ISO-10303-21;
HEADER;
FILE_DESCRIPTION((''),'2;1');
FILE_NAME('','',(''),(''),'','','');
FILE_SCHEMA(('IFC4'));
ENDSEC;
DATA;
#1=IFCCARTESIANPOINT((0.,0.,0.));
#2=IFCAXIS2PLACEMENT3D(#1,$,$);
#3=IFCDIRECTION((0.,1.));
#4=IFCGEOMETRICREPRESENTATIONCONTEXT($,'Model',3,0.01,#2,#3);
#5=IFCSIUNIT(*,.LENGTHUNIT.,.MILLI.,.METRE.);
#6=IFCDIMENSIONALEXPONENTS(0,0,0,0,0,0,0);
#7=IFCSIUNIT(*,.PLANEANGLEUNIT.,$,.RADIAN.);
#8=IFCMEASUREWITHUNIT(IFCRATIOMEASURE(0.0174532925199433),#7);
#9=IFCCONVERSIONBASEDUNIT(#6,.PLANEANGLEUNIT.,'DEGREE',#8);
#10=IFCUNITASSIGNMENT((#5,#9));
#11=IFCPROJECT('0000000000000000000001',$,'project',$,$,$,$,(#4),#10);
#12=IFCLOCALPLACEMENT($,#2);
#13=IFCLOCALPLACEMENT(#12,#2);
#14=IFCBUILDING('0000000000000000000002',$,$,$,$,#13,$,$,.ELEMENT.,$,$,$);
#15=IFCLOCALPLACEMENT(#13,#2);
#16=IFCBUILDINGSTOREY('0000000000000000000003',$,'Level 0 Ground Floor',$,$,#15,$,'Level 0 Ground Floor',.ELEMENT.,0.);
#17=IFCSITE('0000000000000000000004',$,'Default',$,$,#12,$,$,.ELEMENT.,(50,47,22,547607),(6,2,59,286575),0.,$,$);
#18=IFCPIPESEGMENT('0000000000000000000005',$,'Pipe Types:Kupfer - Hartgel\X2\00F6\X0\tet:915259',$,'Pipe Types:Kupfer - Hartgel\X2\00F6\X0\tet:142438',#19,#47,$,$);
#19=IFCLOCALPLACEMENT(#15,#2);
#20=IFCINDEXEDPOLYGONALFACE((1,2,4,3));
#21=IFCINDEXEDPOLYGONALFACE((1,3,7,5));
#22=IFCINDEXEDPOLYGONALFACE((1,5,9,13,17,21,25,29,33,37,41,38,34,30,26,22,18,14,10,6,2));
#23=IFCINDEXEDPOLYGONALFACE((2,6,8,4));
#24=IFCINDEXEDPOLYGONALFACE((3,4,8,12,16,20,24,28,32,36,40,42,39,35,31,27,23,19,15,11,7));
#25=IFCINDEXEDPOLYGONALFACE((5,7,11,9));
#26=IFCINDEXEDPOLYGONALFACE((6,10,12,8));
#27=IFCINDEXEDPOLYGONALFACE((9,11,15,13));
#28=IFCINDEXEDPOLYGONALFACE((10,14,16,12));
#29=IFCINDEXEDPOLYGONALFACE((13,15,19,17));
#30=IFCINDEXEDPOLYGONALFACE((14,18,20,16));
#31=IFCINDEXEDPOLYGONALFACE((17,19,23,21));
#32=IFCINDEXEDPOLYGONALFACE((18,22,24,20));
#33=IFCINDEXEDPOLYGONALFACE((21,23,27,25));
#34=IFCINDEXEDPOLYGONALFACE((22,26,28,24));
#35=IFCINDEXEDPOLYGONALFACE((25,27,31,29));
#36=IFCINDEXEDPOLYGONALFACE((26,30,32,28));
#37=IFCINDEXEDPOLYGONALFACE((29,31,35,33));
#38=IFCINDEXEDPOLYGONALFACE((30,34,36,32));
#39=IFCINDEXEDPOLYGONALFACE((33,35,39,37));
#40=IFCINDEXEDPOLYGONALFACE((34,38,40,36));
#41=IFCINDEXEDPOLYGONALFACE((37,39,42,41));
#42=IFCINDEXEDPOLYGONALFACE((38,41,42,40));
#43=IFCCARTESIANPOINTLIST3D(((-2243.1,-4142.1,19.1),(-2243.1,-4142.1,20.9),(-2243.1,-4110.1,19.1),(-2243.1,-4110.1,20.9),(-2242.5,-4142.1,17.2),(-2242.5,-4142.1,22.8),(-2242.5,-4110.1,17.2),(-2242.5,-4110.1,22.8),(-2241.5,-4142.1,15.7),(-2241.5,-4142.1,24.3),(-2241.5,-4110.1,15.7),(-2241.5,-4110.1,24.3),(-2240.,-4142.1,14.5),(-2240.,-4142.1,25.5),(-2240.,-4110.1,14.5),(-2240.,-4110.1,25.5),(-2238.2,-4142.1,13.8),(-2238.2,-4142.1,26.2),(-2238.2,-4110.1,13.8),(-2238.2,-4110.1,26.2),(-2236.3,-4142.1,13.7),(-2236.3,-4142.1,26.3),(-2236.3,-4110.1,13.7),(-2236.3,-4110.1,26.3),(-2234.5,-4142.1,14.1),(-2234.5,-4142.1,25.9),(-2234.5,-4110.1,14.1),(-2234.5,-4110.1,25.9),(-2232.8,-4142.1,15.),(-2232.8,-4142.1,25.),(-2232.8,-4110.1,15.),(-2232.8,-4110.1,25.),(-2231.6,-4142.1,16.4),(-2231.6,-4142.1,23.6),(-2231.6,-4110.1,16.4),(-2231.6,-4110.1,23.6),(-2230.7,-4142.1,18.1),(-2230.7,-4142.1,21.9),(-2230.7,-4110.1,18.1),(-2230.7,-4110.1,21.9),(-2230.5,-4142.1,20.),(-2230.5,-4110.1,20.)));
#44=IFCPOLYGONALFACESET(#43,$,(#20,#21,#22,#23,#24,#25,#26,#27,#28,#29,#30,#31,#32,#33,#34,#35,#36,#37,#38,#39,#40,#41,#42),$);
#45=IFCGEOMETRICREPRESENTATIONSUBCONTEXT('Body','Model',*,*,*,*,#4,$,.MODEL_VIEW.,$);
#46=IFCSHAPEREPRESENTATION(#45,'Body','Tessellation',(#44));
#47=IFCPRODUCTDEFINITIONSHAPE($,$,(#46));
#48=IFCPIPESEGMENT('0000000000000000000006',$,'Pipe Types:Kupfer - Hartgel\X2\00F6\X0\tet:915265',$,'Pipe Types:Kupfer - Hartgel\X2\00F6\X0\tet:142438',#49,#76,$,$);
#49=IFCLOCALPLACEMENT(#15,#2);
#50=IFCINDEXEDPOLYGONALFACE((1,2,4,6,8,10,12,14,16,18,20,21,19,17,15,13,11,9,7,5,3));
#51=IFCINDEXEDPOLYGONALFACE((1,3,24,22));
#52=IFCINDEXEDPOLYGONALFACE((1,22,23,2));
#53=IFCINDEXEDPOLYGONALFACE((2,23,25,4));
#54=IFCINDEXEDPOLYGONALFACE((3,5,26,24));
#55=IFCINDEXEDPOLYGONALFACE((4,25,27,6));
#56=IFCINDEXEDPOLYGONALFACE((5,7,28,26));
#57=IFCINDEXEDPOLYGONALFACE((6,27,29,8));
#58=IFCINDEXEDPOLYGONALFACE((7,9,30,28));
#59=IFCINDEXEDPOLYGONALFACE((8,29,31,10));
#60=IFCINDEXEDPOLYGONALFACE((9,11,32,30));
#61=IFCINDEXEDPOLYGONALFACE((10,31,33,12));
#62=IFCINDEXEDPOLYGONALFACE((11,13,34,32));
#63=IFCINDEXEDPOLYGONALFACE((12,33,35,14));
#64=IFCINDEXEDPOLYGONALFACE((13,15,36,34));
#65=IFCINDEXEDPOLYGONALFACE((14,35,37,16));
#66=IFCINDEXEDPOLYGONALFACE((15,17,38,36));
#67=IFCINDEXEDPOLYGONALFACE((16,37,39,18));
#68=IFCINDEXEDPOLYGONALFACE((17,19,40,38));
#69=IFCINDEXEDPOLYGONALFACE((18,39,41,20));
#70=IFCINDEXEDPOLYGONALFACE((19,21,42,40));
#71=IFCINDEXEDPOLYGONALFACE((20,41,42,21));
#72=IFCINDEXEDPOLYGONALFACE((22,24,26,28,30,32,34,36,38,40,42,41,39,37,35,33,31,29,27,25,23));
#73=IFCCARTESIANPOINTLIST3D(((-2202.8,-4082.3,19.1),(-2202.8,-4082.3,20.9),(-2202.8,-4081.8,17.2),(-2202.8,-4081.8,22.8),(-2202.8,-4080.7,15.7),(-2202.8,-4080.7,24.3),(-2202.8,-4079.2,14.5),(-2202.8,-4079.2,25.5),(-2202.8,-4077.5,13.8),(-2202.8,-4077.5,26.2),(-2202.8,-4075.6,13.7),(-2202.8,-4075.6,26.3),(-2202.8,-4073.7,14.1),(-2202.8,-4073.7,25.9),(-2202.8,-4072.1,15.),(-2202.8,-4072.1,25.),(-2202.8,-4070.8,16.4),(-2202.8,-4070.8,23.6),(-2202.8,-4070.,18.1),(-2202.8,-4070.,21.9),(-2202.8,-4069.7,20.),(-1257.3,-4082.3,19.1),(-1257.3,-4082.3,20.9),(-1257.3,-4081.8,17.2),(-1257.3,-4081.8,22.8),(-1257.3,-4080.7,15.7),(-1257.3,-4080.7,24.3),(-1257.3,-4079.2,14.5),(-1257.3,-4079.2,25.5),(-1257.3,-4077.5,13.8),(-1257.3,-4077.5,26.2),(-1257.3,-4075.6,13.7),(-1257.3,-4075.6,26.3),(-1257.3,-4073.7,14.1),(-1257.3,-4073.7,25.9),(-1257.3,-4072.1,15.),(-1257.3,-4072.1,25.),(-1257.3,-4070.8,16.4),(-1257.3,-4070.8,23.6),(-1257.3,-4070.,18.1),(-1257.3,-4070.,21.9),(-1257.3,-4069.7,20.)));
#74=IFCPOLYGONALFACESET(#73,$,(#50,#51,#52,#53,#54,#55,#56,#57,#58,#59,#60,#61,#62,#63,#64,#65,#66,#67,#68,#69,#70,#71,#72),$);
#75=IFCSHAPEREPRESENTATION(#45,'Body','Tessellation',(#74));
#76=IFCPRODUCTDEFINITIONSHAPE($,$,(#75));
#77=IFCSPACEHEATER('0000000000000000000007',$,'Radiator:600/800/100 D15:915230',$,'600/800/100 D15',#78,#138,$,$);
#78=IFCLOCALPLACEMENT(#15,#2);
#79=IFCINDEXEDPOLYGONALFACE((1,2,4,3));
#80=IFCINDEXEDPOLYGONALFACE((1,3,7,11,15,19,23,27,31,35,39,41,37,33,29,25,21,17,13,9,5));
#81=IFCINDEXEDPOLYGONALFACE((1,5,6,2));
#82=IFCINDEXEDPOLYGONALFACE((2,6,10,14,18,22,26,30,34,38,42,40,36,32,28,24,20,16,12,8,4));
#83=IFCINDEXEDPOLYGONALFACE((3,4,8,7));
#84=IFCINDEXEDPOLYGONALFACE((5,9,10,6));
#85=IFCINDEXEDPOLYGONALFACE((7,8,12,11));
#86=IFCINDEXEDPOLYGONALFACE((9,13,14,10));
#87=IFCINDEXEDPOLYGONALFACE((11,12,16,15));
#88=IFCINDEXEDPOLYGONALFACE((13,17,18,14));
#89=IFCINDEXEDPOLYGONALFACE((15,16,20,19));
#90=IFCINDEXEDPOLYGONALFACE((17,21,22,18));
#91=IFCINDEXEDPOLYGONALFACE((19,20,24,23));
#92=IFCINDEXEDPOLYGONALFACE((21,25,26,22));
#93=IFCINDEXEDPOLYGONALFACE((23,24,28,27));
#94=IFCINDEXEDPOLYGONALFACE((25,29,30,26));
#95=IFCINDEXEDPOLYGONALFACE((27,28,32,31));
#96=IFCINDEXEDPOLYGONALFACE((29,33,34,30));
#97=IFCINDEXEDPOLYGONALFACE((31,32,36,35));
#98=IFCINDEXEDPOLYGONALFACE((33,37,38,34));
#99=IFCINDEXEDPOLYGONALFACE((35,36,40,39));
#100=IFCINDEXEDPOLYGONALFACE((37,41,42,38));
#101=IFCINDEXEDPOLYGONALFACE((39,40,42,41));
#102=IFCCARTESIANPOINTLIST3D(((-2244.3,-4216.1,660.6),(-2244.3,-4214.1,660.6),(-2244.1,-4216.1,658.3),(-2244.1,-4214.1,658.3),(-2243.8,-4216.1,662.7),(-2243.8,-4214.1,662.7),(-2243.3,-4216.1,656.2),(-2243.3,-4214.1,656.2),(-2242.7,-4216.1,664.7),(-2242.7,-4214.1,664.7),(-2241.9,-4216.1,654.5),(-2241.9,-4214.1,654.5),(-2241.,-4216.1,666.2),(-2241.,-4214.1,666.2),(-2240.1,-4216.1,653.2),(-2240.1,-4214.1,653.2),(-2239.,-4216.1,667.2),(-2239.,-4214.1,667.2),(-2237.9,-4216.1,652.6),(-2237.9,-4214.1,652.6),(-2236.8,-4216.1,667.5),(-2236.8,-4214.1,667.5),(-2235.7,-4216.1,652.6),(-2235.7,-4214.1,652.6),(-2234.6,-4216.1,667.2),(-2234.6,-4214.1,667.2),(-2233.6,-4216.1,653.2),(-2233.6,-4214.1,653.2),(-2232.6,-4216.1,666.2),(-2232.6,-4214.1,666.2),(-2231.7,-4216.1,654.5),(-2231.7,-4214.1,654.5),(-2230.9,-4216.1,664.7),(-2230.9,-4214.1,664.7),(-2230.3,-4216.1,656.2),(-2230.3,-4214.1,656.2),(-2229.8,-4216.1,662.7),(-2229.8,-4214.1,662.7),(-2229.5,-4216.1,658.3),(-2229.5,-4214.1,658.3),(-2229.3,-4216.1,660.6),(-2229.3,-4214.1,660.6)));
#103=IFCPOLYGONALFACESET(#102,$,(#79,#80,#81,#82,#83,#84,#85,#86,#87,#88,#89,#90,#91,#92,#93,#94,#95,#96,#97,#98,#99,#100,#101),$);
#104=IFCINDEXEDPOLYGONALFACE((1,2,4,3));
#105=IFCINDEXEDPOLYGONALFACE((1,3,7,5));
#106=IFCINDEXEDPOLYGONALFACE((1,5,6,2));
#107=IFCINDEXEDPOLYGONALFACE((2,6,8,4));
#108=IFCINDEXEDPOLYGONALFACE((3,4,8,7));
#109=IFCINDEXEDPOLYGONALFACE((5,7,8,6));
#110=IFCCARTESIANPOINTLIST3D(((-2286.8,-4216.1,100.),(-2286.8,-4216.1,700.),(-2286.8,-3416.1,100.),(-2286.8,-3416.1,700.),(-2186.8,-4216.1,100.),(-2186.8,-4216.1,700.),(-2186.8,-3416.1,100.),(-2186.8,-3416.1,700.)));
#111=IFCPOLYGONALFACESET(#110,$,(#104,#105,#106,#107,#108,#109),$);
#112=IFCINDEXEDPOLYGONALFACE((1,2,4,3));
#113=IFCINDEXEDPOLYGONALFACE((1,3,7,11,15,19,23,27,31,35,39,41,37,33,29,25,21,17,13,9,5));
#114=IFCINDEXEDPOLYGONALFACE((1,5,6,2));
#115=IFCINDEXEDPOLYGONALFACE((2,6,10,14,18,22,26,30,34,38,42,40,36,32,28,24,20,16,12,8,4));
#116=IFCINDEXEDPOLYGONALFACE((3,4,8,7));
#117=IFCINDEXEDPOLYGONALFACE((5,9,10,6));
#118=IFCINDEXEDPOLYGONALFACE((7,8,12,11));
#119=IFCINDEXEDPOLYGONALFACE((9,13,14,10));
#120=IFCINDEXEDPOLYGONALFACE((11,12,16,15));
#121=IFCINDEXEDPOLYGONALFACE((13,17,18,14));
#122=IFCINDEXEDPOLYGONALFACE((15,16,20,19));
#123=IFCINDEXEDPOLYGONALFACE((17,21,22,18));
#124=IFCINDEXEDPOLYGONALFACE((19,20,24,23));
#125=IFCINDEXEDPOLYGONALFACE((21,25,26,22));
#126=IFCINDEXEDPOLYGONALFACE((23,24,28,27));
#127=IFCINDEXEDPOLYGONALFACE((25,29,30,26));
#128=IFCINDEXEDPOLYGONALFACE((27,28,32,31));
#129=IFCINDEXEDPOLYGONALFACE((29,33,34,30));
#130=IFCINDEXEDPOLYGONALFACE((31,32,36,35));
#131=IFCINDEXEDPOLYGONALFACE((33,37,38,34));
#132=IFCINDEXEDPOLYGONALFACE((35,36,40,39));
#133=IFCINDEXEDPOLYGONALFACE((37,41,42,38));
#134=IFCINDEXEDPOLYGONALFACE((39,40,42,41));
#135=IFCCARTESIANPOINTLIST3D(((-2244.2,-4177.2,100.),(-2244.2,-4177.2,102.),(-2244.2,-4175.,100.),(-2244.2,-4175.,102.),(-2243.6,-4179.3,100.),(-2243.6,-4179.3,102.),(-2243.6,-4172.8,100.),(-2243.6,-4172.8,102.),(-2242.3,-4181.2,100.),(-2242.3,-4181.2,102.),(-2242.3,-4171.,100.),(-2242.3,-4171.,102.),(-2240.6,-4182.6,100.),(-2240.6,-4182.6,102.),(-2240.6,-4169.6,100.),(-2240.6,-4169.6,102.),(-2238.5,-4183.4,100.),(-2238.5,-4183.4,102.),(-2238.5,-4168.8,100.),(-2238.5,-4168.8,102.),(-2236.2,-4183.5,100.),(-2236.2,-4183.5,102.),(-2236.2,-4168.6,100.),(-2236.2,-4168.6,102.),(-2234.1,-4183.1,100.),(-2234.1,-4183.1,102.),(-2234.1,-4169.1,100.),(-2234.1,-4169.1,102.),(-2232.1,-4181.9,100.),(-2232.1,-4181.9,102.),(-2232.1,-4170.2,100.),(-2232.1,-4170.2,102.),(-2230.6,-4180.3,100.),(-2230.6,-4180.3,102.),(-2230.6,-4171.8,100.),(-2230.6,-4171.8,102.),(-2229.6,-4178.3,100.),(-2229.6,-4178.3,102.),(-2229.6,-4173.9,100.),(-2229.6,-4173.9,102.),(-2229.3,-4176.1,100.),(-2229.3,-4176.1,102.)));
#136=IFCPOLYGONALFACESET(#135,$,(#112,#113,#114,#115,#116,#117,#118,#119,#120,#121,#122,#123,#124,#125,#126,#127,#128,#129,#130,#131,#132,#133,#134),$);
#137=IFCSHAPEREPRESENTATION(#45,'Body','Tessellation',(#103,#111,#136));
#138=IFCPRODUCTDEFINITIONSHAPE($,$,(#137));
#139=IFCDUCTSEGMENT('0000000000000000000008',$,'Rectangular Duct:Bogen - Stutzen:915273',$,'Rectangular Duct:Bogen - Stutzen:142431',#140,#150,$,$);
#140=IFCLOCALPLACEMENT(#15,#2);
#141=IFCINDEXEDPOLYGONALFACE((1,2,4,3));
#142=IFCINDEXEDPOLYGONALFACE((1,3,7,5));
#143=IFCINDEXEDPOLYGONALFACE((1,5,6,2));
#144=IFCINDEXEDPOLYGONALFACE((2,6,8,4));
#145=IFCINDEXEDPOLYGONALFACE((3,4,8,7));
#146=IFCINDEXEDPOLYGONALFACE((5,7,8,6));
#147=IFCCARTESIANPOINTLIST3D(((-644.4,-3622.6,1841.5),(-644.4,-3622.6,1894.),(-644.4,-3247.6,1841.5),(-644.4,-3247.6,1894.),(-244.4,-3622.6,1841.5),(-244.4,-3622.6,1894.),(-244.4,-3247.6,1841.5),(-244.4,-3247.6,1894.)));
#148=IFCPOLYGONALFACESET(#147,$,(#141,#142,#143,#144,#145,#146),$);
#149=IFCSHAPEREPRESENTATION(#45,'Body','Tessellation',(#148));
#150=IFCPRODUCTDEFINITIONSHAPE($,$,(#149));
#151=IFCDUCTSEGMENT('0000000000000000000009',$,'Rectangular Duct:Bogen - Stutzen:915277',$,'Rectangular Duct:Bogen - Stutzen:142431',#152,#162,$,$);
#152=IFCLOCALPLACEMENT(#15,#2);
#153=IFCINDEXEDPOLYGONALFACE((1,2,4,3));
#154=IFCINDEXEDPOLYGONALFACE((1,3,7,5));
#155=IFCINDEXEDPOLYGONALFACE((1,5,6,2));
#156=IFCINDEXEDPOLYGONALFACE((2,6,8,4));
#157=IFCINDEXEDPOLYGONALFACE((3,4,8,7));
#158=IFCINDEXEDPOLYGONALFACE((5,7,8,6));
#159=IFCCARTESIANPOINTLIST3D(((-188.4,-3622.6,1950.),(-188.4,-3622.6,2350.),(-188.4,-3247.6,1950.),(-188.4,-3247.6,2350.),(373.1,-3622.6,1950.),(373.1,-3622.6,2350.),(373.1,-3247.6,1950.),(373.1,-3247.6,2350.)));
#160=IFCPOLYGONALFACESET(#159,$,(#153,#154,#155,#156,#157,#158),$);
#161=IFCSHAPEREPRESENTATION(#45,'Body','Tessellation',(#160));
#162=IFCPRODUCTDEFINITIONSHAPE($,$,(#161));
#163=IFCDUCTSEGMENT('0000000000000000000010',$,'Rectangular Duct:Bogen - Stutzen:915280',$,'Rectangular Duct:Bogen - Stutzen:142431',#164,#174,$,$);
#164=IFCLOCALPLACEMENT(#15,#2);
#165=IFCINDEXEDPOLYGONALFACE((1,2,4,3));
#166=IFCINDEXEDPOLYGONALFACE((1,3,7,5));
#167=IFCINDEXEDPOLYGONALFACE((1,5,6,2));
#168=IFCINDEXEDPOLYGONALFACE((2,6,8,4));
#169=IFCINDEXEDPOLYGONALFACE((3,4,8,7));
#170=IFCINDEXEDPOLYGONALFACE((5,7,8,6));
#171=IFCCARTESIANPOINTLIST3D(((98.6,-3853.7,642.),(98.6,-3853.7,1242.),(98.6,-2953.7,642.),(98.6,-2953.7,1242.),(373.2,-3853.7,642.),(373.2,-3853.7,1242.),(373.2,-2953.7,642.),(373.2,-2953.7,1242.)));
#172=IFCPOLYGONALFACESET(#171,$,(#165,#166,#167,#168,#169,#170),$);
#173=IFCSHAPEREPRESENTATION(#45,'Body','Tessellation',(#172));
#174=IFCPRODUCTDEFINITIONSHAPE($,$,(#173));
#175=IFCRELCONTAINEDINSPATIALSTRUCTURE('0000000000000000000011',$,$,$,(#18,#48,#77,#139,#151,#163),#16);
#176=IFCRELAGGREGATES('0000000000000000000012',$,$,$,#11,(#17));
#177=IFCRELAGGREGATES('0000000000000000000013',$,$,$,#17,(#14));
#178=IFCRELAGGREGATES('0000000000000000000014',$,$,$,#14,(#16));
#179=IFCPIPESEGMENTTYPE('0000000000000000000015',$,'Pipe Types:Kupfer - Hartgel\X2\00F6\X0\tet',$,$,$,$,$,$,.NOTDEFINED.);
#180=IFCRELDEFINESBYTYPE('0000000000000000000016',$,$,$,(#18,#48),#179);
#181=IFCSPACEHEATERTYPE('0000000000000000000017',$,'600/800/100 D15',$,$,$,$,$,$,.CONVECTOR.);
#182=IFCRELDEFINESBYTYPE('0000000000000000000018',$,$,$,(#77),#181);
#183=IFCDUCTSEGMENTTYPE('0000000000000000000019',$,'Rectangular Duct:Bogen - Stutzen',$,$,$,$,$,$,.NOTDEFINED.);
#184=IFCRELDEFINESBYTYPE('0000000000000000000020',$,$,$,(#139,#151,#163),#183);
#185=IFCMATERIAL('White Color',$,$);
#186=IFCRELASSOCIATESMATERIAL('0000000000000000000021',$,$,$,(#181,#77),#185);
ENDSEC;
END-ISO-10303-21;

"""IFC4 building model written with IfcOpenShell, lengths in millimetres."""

from ifc_helpers import new_model, entity, si_unit, converted_unit, direction, frame, frame_2d, origin, origin_2d_with_axis, place, context, subcontext, project, spatial, rectangle, circle, extrude, source, transform, mapped, material, type_object, type_shapes, element, save


model = new_model("IFC4")

# Units and contexts
model_context = context("Model", 3, precision=0.01, world=origin(), true_north=direction((0.0, 1.0)))
body_context = subcontext(model_context, "Body", "Model", "MODEL_VIEW")
ifc_project = project(units=[si_unit("LENGTHUNIT", "METRE", prefix="MILLI"), converted_unit("PLANEANGLEUNIT", "DEGREE", entity("IfcRatioMeasure", 0.0174532925199433), si_unit("PLANEANGLEUNIT", "RADIAN"), dimensions=[0, 0, 0, 0, 0, 0, 0])], contexts=[model_context])

# Site, building, storey
site_placement = place(None, origin())
site = spatial("IfcSite", under=ifc_project, at=site_placement, Name="Default", CompositionType="ELEMENT", RefLatitude=(50, 47, 22, 547607), RefLongitude=(6, 2, 59, 286575), RefElevation=0.0)
building_placement = place(site_placement, origin())
building = spatial("IfcBuilding", under=site, at=building_placement, CompositionType="ELEMENT")
storey_placement = place(building_placement, origin())
storey = spatial("IfcBuildingStorey", under=building, at=storey_placement, Name="Level 0 Ground Floor", LongName="Level 0 Ground Floor", CompositionType="ELEMENT", Elevation=0.0)

# Pipe segments
pipe_segment_type = type_object("IfcPipeSegmentType", Name="Pipe Types:Kupfer - Hartgelötet", PredefinedType="NOTDEFINED")
pipe_segment_1_placement = place(storey_placement, frame((-2244.8, -4142.1, 12.1)))
element("IfcPipeSegment", 1, at=pipe_segment_1_placement, inside=storey, type_object=pipe_segment_type, Name="Pipe Types:Kupfer - Hartgelötet:915259", ObjectType="Pipe Types:Kupfer - Hartgelötet:142438", context=body_context, shape_type="SweptSolid", body=[
    extrude(circle(Radius=6.3, at=frame_2d((0.0, 0.0), x_axis=(1.0, 0.0))), frame((7.9, 0.0, 7.9), z_axis=(0.0, 1.0, 0.0), x_axis=(1.0, 0.0, 0.0)), (0.0, 0.0, 1.0), 32.0),
])
pipe_segment_2_placement = place(storey_placement, frame((-2202.8, -4084.0, 12.1)))
element("IfcPipeSegment", 2, at=pipe_segment_2_placement, inside=storey, type_object=pipe_segment_type, Name="Pipe Types:Kupfer - Hartgelötet:915265", ObjectType="Pipe Types:Kupfer - Hartgelötet:142438", context=body_context, shape_type="SweptSolid", body=[
    extrude(circle(Radius=6.3, at=frame_2d((0.0, 0.0), x_axis=(1.0, 0.0))), frame((0.0, 7.9, 7.9), z_axis=(1.0, 0.0, 0.0), x_axis=(0.0, 1.0, 0.0)), (0.0, 0.0, 1.0), 945.5),
])

# Space heater
ifc_material = material(Name="White Color")
space_heater_type = type_object("IfcSpaceHeaterType", Name="600/800/100 D15", PredefinedType="CONVECTOR", material=ifc_material)
shared_shape_1 = source(origin(), body_context, "Body", "SweptSolid", [
    extrude(circle(Radius=7.5, at=frame_2d((0.0, 0.0), x_axis=(1.0, 0.0))), frame((798.0, 50.0, 560.0), z_axis=(1.0, 0.0, 0.0), x_axis=(0.0, 0.0, 1.0)), (0.0, 0.0, 1.0), 2.0),
    extrude(rectangle(XDim=100.0, YDim=800.0, at=frame_2d((0.0, 0.0), x_axis=(1.0, 0.0))), frame((400.0, 50.0, 0.0), z_axis=(0.0, 0.0, 1.0), x_axis=(0.0, 1.0, 0.0)), (0.0, 0.0, 1.0), 600.0),
    extrude(circle(Radius=7.5, at=frame_2d((0.0, 0.0), x_axis=(1.0, 0.0))), frame((760.0, 50.0, 0.0), z_axis=(0.0, 0.0, 1.0), x_axis=(0.0, 1.0, 0.0)), (0.0, 0.0, 1.0), 2.0),
])
type_shapes(space_heater_type, [shared_shape_1])
space_heater_placement = place(storey_placement, frame((-2286.8, -3416.1, 100.0), z_axis=(0.0, 0.0, 1.0), x_axis=(0.000017, -1.0, 0.0)))
element("IfcSpaceHeater", 3, at=space_heater_placement, inside=storey, type_object=space_heater_type, material=ifc_material, Name="Radiator:600/800/100 D15:915230", ObjectType="600/800/100 D15", context=body_context, shape_type="MappedRepresentation", body=[
    mapped(shared_shape_1, transform((0.0, 0.0, 0.0), scale=1.0)),
])

# Duct segments
duct_segment_type = type_object("IfcDuctSegmentType", Name="Rectangular Duct:Bogen - Stutzen", PredefinedType="NOTDEFINED")
duct_segment_1_placement = place(storey_placement, frame((-644.4, -3622.6, 1841.5)))
element("IfcDuctSegment", 4, at=duct_segment_1_placement, inside=storey, type_object=duct_segment_type, Name="Rectangular Duct:Bogen - Stutzen:915273", ObjectType="Rectangular Duct:Bogen - Stutzen:142431", context=body_context, shape_type="SweptSolid", body=[
    extrude(rectangle(XDim=375.0, YDim=400.0, at=origin_2d_with_axis()), frame((200.0, 187.5, 0.0), z_axis=(0.0, 0.0, 1.0), x_axis=(0.0, 1.0, 0.0)), (0.0, 0.0, 1.0), 52.5),
])
duct_segment_2_placement = place(storey_placement, frame((-188.4, -3622.6, 1950.0)))
element("IfcDuctSegment", 5, at=duct_segment_2_placement, inside=storey, type_object=duct_segment_type, Name="Rectangular Duct:Bogen - Stutzen:915277", ObjectType="Rectangular Duct:Bogen - Stutzen:142431", context=body_context, shape_type="SweptSolid", body=[
    extrude(rectangle(XDim=561.5, YDim=375.0, at=origin_2d_with_axis()), frame((280.8, 187.5, 0.0)), (0.0, 0.0, 1.0), 400.0),
])
duct_segment_3_placement = place(storey_placement, frame((98.6, -3853.7, 642.0)))
element("IfcDuctSegment", 6, at=duct_segment_3_placement, inside=storey, type_object=duct_segment_type, Name="Rectangular Duct:Bogen - Stutzen:915280", ObjectType="Rectangular Duct:Bogen - Stutzen:142431", context=body_context, shape_type="SweptSolid", body=[
    extrude(rectangle(XDim=274.6, YDim=900.0, at=frame_2d((0.0, 0.0), x_axis=(1.0, 0.0))), frame((137.3, 450.0, 0.0)), (0.0, 0.0, 1.0), 600.0),
])

save(model, "model.ifc")
